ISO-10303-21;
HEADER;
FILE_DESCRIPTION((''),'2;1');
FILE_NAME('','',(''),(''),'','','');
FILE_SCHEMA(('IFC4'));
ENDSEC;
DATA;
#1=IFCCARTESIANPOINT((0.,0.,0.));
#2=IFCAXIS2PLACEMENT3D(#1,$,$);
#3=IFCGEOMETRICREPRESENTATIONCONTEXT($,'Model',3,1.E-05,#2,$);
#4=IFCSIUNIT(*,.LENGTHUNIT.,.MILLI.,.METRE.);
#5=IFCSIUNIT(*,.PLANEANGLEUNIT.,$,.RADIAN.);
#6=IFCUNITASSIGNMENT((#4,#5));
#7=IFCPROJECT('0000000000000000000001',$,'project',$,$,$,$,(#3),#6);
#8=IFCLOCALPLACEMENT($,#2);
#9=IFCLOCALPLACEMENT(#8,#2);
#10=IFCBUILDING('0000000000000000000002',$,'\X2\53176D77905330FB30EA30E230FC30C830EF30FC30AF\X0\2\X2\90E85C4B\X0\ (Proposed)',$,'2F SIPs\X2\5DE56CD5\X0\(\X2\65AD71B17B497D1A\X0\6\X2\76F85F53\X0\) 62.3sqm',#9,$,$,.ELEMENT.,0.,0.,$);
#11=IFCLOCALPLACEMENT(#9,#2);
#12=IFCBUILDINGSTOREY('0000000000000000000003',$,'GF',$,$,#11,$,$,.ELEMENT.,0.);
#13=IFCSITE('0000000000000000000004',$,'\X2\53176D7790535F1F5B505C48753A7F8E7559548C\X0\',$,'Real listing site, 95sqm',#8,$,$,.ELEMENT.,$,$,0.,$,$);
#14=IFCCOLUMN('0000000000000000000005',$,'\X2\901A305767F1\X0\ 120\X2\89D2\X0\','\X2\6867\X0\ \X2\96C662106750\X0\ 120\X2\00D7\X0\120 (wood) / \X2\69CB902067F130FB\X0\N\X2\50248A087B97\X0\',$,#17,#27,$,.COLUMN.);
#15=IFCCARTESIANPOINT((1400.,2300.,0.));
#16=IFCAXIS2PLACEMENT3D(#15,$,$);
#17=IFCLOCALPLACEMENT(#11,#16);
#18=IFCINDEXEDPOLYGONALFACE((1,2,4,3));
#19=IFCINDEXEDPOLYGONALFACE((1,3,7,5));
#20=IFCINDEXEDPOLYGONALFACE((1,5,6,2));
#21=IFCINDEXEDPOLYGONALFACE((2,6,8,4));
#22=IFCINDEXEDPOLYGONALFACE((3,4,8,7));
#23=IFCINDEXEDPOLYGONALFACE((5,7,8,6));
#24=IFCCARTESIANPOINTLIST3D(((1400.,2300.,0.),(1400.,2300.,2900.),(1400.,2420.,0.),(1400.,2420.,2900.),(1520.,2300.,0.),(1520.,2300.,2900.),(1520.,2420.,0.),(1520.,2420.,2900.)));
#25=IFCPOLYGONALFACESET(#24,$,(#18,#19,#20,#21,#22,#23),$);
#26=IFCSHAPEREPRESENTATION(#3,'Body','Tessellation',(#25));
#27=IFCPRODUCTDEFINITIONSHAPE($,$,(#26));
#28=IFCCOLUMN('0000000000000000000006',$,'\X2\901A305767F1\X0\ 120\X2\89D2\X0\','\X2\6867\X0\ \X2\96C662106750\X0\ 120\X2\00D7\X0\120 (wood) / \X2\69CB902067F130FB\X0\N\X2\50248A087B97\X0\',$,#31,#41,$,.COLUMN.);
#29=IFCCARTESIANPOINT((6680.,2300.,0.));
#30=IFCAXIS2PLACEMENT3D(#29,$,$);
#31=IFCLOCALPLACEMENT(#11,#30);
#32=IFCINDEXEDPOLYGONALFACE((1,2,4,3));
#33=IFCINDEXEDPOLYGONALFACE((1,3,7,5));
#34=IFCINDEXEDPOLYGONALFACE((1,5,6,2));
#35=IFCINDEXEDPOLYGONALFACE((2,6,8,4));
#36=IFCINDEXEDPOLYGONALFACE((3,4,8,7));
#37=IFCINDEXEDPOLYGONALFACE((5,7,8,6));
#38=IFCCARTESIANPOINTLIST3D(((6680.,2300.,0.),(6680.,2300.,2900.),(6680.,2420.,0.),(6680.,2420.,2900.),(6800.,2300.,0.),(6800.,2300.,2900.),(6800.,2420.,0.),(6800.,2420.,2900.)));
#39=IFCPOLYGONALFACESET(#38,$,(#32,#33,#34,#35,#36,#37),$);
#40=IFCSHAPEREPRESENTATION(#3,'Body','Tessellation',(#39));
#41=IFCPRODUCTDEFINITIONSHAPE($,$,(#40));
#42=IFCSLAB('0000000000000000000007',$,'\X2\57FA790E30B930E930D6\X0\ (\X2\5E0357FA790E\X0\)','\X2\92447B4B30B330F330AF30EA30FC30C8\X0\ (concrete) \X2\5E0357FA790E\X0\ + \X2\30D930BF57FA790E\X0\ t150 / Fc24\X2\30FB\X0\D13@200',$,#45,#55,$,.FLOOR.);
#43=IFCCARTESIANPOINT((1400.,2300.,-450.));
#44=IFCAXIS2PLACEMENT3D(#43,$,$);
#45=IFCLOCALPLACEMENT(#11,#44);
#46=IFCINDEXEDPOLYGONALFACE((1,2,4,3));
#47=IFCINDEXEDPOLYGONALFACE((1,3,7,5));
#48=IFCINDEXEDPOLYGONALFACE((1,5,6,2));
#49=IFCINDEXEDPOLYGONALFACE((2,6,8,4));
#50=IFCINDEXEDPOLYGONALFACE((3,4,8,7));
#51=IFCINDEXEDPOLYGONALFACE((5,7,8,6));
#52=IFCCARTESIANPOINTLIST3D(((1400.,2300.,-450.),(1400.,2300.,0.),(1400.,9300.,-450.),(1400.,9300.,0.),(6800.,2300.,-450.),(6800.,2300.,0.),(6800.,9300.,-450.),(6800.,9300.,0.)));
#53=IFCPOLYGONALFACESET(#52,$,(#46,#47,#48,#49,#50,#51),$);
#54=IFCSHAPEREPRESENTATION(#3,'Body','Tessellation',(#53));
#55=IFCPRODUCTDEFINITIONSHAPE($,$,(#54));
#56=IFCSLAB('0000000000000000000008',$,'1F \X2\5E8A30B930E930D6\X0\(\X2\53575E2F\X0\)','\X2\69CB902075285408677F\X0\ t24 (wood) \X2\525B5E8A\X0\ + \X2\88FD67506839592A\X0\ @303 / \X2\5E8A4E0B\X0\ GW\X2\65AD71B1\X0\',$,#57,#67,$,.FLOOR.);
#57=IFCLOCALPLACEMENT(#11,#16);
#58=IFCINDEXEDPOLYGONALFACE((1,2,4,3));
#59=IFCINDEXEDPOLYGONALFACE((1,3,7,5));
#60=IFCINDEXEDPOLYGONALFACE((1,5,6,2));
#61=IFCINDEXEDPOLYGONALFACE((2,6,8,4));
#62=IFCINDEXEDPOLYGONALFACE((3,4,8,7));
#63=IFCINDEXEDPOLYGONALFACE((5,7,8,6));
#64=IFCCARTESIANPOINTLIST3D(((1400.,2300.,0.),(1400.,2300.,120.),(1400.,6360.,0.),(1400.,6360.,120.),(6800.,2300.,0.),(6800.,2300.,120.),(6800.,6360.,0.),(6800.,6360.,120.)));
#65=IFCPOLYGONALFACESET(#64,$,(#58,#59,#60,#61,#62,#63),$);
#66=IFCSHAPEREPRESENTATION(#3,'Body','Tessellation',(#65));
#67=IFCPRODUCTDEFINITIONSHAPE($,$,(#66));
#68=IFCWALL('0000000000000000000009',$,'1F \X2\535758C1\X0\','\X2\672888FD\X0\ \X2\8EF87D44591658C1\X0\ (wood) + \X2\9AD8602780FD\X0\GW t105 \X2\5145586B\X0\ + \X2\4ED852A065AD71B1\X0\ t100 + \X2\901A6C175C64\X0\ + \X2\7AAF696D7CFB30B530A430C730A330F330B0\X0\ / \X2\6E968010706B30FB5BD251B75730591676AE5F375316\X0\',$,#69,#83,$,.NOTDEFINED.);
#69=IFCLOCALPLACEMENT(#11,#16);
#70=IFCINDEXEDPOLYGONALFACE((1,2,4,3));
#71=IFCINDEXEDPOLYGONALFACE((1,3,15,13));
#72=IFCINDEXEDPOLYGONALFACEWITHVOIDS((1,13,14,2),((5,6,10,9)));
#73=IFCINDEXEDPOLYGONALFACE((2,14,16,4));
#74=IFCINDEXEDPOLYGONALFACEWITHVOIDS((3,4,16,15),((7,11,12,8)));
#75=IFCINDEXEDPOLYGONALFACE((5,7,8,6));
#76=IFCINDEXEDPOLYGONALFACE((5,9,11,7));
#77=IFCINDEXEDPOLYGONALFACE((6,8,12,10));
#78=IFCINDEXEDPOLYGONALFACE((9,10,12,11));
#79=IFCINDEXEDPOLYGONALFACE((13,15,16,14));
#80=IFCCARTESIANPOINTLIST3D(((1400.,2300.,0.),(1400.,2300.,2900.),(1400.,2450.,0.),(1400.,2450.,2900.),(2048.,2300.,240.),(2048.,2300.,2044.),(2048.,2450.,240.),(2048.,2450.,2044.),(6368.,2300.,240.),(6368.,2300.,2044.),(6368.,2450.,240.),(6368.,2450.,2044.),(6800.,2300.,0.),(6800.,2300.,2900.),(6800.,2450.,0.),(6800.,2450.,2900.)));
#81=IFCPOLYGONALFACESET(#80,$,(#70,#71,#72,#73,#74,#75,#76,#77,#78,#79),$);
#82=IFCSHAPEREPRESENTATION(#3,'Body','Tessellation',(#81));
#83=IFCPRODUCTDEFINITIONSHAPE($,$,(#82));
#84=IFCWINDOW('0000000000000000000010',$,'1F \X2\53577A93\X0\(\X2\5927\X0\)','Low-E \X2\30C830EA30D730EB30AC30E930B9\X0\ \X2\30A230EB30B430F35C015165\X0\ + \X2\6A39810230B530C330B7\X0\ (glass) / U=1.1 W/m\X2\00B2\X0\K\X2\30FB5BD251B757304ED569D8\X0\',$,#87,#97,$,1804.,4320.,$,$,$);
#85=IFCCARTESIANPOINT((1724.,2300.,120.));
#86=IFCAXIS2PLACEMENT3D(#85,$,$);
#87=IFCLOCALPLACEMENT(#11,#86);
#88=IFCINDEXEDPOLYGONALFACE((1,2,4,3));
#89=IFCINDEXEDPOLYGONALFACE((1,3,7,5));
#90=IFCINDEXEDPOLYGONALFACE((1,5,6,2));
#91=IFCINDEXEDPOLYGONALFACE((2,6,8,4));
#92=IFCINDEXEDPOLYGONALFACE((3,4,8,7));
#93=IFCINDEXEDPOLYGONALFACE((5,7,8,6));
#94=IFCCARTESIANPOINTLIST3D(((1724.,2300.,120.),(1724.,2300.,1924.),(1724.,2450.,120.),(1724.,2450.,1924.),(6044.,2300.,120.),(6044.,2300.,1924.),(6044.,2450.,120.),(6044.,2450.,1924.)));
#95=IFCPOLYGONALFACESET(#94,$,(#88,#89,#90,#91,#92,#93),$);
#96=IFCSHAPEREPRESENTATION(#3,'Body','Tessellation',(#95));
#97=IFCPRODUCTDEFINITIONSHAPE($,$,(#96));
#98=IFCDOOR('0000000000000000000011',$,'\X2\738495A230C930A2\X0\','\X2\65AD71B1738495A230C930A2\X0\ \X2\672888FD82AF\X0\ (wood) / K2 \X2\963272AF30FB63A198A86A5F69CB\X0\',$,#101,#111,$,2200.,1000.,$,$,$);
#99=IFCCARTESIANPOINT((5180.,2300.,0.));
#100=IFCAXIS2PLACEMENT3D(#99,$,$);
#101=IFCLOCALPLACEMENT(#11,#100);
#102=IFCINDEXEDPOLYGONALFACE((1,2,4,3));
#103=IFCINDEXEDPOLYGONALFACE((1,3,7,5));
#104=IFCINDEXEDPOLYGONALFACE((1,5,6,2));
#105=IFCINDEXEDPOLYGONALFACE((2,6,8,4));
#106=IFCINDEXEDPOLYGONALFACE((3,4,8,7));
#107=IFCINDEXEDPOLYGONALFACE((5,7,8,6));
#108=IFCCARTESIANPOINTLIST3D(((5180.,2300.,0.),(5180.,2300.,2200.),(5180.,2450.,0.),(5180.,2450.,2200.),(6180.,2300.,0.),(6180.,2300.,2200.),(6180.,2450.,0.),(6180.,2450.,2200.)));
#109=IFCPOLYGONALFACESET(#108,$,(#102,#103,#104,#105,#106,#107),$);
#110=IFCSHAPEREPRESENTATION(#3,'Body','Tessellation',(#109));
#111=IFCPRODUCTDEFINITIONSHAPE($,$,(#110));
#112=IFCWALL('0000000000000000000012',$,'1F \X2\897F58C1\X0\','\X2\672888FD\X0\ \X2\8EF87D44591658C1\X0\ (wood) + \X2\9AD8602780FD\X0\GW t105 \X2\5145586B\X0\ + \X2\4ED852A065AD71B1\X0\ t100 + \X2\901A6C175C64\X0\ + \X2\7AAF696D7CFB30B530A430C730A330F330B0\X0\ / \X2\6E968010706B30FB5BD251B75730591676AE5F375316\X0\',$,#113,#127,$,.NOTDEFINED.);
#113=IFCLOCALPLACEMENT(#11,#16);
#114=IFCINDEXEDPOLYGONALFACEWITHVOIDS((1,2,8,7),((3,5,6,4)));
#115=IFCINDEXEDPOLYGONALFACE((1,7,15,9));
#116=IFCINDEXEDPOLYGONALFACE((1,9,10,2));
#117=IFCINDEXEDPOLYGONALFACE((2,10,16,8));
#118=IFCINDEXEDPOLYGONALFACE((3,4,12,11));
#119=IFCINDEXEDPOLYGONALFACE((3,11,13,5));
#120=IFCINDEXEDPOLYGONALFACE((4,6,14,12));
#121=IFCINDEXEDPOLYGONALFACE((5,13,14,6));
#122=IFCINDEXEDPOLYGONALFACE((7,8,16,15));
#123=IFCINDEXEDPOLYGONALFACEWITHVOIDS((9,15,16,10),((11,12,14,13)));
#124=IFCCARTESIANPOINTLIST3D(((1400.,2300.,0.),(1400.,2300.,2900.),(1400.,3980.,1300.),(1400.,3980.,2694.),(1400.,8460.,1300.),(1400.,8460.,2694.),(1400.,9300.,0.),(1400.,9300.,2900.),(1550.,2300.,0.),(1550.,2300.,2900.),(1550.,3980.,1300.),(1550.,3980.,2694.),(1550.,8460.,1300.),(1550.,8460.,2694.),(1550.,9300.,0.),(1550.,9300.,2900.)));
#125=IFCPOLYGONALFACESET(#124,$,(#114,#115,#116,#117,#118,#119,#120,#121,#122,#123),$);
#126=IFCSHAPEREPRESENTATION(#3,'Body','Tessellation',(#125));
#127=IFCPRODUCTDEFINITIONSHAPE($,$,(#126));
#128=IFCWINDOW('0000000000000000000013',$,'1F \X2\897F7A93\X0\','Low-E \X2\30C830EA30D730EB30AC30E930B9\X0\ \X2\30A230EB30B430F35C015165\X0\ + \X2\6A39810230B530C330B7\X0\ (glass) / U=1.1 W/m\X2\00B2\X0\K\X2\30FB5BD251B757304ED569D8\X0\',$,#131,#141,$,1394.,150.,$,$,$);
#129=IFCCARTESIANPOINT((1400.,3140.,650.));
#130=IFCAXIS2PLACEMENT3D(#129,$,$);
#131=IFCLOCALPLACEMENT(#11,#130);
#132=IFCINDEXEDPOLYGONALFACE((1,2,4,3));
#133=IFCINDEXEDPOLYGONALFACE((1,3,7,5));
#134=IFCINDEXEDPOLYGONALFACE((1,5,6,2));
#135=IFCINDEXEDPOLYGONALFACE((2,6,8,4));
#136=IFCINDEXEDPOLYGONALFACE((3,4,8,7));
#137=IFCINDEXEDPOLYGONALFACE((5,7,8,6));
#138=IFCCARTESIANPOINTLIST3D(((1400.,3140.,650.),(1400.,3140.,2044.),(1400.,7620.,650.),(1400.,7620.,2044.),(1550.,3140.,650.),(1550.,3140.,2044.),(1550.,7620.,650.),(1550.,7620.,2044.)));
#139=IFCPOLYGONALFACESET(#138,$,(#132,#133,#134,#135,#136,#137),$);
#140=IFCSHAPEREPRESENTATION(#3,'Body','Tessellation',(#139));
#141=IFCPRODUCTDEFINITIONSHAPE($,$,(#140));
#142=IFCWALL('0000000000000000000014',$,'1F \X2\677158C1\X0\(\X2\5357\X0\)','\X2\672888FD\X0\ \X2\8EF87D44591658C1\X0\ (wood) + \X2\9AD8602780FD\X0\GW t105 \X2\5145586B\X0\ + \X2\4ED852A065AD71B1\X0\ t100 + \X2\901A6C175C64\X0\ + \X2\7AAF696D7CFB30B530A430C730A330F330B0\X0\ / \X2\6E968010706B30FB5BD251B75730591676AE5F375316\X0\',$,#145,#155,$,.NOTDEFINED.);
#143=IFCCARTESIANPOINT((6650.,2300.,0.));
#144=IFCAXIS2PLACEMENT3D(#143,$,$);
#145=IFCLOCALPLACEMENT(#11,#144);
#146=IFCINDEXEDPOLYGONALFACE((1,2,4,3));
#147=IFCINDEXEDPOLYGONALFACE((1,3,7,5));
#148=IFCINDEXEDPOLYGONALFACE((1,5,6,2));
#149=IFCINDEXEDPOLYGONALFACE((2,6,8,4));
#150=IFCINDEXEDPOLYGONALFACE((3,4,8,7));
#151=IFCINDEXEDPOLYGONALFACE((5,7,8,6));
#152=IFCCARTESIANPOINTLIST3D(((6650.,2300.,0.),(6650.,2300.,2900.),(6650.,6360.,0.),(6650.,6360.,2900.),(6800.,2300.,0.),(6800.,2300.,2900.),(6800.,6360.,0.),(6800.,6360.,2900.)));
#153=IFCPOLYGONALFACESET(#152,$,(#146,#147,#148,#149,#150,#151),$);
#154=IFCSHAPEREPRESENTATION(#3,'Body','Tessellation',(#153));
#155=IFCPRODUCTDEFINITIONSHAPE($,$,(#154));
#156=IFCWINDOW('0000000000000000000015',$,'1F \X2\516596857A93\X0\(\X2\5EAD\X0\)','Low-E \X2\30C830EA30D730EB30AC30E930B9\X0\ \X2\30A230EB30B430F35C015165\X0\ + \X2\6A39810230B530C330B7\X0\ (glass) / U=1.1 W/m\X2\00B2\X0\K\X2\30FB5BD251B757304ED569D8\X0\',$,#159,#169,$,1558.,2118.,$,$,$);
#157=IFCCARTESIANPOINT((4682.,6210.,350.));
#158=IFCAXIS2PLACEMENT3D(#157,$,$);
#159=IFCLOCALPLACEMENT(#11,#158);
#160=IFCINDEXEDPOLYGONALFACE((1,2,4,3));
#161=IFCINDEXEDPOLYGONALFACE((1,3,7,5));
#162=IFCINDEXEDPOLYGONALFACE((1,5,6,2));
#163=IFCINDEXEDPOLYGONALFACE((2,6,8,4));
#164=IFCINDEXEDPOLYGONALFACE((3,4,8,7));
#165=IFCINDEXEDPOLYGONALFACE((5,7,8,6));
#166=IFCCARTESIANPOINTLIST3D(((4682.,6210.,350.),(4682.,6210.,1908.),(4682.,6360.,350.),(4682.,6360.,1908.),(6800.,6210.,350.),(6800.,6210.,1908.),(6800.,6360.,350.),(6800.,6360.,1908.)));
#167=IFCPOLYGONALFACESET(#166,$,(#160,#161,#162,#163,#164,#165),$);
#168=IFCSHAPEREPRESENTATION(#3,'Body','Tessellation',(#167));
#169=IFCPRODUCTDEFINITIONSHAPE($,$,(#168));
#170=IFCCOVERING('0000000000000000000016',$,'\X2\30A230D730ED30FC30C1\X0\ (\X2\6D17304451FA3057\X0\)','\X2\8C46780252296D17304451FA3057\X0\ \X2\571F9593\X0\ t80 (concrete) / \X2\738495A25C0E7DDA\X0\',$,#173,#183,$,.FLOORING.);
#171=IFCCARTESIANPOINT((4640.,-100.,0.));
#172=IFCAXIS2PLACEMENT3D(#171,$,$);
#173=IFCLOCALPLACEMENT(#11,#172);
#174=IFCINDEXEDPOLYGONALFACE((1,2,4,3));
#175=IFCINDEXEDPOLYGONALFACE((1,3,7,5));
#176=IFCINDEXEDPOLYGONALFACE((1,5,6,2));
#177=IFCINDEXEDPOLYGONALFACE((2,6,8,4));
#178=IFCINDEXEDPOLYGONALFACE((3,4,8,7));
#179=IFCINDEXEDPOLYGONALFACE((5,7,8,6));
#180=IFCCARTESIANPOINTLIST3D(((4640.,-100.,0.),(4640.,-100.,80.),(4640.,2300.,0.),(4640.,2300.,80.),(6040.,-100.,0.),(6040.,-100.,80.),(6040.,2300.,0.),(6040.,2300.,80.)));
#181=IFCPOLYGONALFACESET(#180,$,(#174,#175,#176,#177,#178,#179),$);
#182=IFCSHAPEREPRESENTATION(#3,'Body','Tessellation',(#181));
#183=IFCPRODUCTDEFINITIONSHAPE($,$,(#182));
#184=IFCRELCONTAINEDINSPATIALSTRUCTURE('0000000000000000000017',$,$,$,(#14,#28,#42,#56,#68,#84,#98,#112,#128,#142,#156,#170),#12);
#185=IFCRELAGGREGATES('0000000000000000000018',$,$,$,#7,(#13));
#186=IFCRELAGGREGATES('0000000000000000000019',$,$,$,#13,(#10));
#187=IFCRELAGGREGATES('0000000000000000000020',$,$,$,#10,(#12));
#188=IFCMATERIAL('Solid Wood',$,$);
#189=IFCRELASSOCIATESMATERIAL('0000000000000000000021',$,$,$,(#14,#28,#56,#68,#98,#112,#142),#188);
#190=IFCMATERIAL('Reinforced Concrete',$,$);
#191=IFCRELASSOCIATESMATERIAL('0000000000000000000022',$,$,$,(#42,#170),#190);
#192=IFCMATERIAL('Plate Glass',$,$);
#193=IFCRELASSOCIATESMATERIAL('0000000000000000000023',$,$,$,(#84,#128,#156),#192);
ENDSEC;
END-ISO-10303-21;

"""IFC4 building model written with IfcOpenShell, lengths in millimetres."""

from ifc_helpers import new_model, si_unit, frame, frame_2d, origin, place, context, project, spatial, rectangle, extrude, material, element, fill, save


model = new_model("IFC4")

# Units and contexts
model_context = context("Model", 3, precision=1e-05, world=origin())
ifc_project = project(units=[si_unit("LENGTHUNIT", "METRE", prefix="MILLI"), si_unit("PLANEANGLEUNIT", "RADIAN")], contexts=[model_context])

# Site, building, storey
site_placement = place(None, origin())
site = spatial("IfcSite", under=ifc_project, at=site_placement, Name="北海道弟子屈町美留和", ObjectType="Real listing site, 95sqm", CompositionType="ELEMENT", RefElevation=0.0)
building_placement = place(site_placement, origin())
building = spatial("IfcBuilding", under=site, at=building_placement, Name="北海道・リモートワーク2部屋 (Proposed)", ObjectType="2F SIPs工法(断熱等級6相当) 62.3sqm", CompositionType="ELEMENT", ElevationOfRefHeight=0.0, ElevationOfTerrain=0.0)
storey_placement = place(building_placement, origin())
storey = spatial("IfcBuildingStorey", under=building, at=storey_placement, Name="GF", CompositionType="ELEMENT", Elevation=0.0)

# Columns
ifc_material_1 = material(Name="Solid Wood")
column_1_placement = place(storey_placement, frame((1400.0, 2300.0, 0.0)))
element("IfcColumn", 1, at=column_1_placement, inside=storey, material=ifc_material_1, Name="通し柱 120角", Description="桧 集成材 120×120 (wood) / 構造柱・N値計算", PredefinedType="COLUMN", context=model_context, shape_type="SweptSolid", body=[
    extrude(rectangle(XDim=120.0, YDim=120.0, at=frame_2d((60.0, 60.0))), frame((1400.0, 2300.0, 0.0)), (0.0, 0.0, 1.0), 2900.0),
])
column_2_placement = place(storey_placement, frame((6680.0, 2300.0, 0.0)))
element("IfcColumn", 2, at=column_2_placement, inside=storey, material=ifc_material_1, Name="通し柱 120角", Description="桧 集成材 120×120 (wood) / 構造柱・N値計算", PredefinedType="COLUMN", context=model_context, shape_type="SweptSolid", body=[
    extrude(rectangle(XDim=120.0, YDim=120.0, at=frame_2d((60.0, 60.0))), frame((6680.0, 2300.0, 0.0)), (0.0, 0.0, 1.0), 2900.0),
])

# Slabs
ifc_material_2 = material(Name="Reinforced Concrete")
slab_1_placement = place(storey_placement, frame((1400.0, 2300.0, -450.0)))
element("IfcSlab", 3, at=slab_1_placement, inside=storey, material=ifc_material_2, Name="基礎スラブ (布基礎)", Description="鉄筋コンクリート (concrete) 布基礎 + ベタ基礎 t150 / Fc24・D13@200", PredefinedType="FLOOR", context=model_context, shape_type="SweptSolid", body=[
    extrude(rectangle(XDim=5400.0, YDim=7000.0, at=frame_2d((2700.0, 3500.0))), frame((1400.0, 2300.0, -450.0)), (0.0, 0.0, 1.0), 450.0),
])
slab_2_placement = place(storey_placement, frame((1400.0, 2300.0, 0.0)))
element("IfcSlab", 4, at=slab_2_placement, inside=storey, material=ifc_material_1, Name="1F 床スラブ(南帯)", Description="構造用合板 t24 (wood) 剛床 + 製材根太 @303 / 床下 GW断熱", PredefinedType="FLOOR", context=model_context, shape_type="SweptSolid", body=[
    extrude(rectangle(XDim=5400.0, YDim=4060.0, at=frame_2d((2700.0, 2030.0))), frame((1400.0, 2300.0, 0.0)), (0.0, 0.0, 1.0), 120.0),
])

# Wall, openings, window, door
wall_1_placement = place(storey_placement, frame((1400.0, 2300.0, 0.0)))
wall_1 = element("IfcWall", 5, at=wall_1_placement, inside=storey, material=ifc_material_1, Name="1F 南壁", Description="木製 軸組外壁 (wood) + 高性能GW t105 充填 + 付加断熱 t100 + 通気層 + 窯業系サイディング / 準耐火・寒冷地外皮強化", PredefinedType="NOTDEFINED", context=model_context, shape_type="SweptSolid", body=[
    extrude(rectangle(XDim=5400.0, YDim=150.0, at=frame_2d((2700.0, 75.0))), frame((1400.0, 2300.0, 0.0)), (0.0, 0.0, 1.0), 2900.0),
])
opening_1_placement = place(storey_placement, frame((1724.0, 2300.0, 120.0)))
opening_1 = element("IfcOpeningElement", 6, at=opening_1_placement, cuts=wall_1, PredefinedType="NOTDEFINED", context=model_context, shape_type="SweptSolid", body=[
    extrude(rectangle(XDim=4320.0, YDim=150.0, at=frame_2d((2160.0, 75.0))), frame((1724.0, 2300.0, 120.0)), (0.0, 0.0, 1.0), 1804.0),
])
opening_2_placement = place(storey_placement, frame((5180.0, 2300.0, 0.0)))
opening_2 = element("IfcOpeningElement", 7, at=opening_2_placement, cuts=wall_1, PredefinedType="NOTDEFINED", context=model_context, shape_type="SweptSolid", body=[
    extrude(rectangle(XDim=1000.0, YDim=150.0, at=frame_2d((500.0, 75.0))), frame((5180.0, 2300.0, 0.0)), (0.0, 0.0, 1.0), 2200.0),
])
ifc_material_3 = material(Name="Plate Glass")
window_1_placement = place(storey_placement, frame((1724.0, 2300.0, 120.0)))
window_1 = element("IfcWindow", 8, at=window_1_placement, inside=storey, material=ifc_material_3, Name="1F 南窓(大)", Description="Low-E トリプルガラス アルゴン封入 + 樹脂サッシ (glass) / U=1.1 W/m²K・寒冷地仕様", OverallHeight=1804.0, OverallWidth=4320.0, context=model_context, shape_type="SweptSolid", body=[
    extrude(rectangle(XDim=4320.0, YDim=150.0, at=frame_2d((2160.0, 75.0))), frame((1724.0, 2300.0, 120.0)), (0.0, 0.0, 1.0), 1804.0),
])
fill(opening_1, window_1)
door_1_placement = place(storey_placement, frame((5180.0, 2300.0, 0.0)))
door_1 = element("IfcDoor", 9, at=door_1_placement, inside=storey, material=ifc_material_1, Name="玄関ドア", Description="断熱玄関ドア 木製芯 (wood) / K2 防犯・採風機構", OverallHeight=2200.0, OverallWidth=1000.0, context=model_context, shape_type="SweptSolid", body=[
    extrude(rectangle(XDim=1000.0, YDim=150.0, at=frame_2d((500.0, 75.0))), frame((5180.0, 2300.0, 0.0)), (0.0, 0.0, 1.0), 2200.0),
])
fill(opening_2, door_1)

# Walls, openings, windows
wall_2_placement = place(storey_placement, frame((1400.0, 2300.0, 0.0)))
wall_2 = element("IfcWall", 10, at=wall_2_placement, inside=storey, material=ifc_material_1, Name="1F 西壁", Description="木製 軸組外壁 (wood) + 高性能GW t105 充填 + 付加断熱 t100 + 通気層 + 窯業系サイディング / 準耐火・寒冷地外皮強化", PredefinedType="NOTDEFINED", context=model_context, shape_type="SweptSolid", body=[
    extrude(rectangle(XDim=150.0, YDim=7000.0, at=frame_2d((75.0, 3500.0))), frame((1400.0, 2300.0, 0.0)), (0.0, 0.0, 1.0), 2900.0),
])
opening_3_placement = place(storey_placement, frame((1400.0, 3140.0, 650.0)))
opening_3 = element("IfcOpeningElement", 11, at=opening_3_placement, cuts=wall_2, PredefinedType="NOTDEFINED", context=model_context, shape_type="SweptSolid", body=[
    extrude(rectangle(XDim=150.0, YDim=4480.0, at=frame_2d((75.0, 2240.0))), frame((1400.0, 3140.0, 650.0)), (0.0, 0.0, 1.0), 1394.0),
])
window_2_placement = place(storey_placement, frame((1400.0, 3140.0, 650.0)))
window_2 = element("IfcWindow", 12, at=window_2_placement, inside=storey, material=ifc_material_3, Name="1F 西窓", Description="Low-E トリプルガラス アルゴン封入 + 樹脂サッシ (glass) / U=1.1 W/m²K・寒冷地仕様", OverallHeight=1394.0, OverallWidth=150.0, context=model_context, shape_type="SweptSolid", body=[
    extrude(rectangle(XDim=150.0, YDim=4480.0, at=frame_2d((75.0, 2240.0))), frame((1400.0, 3140.0, 650.0)), (0.0, 0.0, 1.0), 1394.0),
])
fill(opening_3, window_2)
wall_3_placement = place(storey_placement, frame((6650.0, 2300.0, 0.0)))
wall_3 = element("IfcWall", 13, at=wall_3_placement, inside=storey, material=ifc_material_1, Name="1F 東壁(南)", Description="木製 軸組外壁 (wood) + 高性能GW t105 充填 + 付加断熱 t100 + 通気層 + 窯業系サイディング / 準耐火・寒冷地外皮強化", PredefinedType="NOTDEFINED", context=model_context, shape_type="SweptSolid", body=[
    extrude(rectangle(XDim=150.0, YDim=4060.0, at=frame_2d((75.0, 2030.0))), frame((6650.0, 2300.0, 0.0)), (0.0, 0.0, 1.0), 2900.0),
])
opening_4_placement = place(storey_placement, frame((4682.0, 6210.0, 350.0)))
opening_4 = element("IfcOpeningElement", 14, at=opening_4_placement, cuts=wall_3, PredefinedType="NOTDEFINED", context=model_context, shape_type="SweptSolid", body=[
    extrude(rectangle(XDim=2118.0, YDim=150.0, at=frame_2d((1059.0, 75.0))), frame((4682.0, 6210.0, 350.0)), (0.0, 0.0, 1.0), 1558.0),
])
window_3_placement = place(storey_placement, frame((4682.0, 6210.0, 350.0)))
window_3 = element("IfcWindow", 15, at=window_3_placement, inside=storey, material=ifc_material_3, Name="1F 入隅窓(庭)", Description="Low-E トリプルガラス アルゴン封入 + 樹脂サッシ (glass) / U=1.1 W/m²K・寒冷地仕様", OverallHeight=1558.0, OverallWidth=2118.0, context=model_context, shape_type="SweptSolid", body=[
    extrude(rectangle(XDim=2118.0, YDim=150.0, at=frame_2d((1059.0, 75.0))), frame((4682.0, 6210.0, 350.0)), (0.0, 0.0, 1.0), 1558.0),
])
fill(opening_4, window_3)

# Covering
covering_1_placement = place(storey_placement, frame((4640.0, -100.0, 0.0)))
element("IfcCovering", 16, at=covering_1_placement, inside=storey, material=ifc_material_2, Name="アプローチ (洗い出し)", Description="豆砂利洗い出し 土間 t80 (concrete) / 玄関導線", PredefinedType="FLOORING", context=model_context, shape_type="SweptSolid", body=[
    extrude(rectangle(XDim=1400.0, YDim=2400.0, at=frame_2d((700.0, 1200.0))), frame((4640.0, -100.0, 0.0)), (0.0, 0.0, 1.0), 80.0),
])

save(model, "model.ifc")
